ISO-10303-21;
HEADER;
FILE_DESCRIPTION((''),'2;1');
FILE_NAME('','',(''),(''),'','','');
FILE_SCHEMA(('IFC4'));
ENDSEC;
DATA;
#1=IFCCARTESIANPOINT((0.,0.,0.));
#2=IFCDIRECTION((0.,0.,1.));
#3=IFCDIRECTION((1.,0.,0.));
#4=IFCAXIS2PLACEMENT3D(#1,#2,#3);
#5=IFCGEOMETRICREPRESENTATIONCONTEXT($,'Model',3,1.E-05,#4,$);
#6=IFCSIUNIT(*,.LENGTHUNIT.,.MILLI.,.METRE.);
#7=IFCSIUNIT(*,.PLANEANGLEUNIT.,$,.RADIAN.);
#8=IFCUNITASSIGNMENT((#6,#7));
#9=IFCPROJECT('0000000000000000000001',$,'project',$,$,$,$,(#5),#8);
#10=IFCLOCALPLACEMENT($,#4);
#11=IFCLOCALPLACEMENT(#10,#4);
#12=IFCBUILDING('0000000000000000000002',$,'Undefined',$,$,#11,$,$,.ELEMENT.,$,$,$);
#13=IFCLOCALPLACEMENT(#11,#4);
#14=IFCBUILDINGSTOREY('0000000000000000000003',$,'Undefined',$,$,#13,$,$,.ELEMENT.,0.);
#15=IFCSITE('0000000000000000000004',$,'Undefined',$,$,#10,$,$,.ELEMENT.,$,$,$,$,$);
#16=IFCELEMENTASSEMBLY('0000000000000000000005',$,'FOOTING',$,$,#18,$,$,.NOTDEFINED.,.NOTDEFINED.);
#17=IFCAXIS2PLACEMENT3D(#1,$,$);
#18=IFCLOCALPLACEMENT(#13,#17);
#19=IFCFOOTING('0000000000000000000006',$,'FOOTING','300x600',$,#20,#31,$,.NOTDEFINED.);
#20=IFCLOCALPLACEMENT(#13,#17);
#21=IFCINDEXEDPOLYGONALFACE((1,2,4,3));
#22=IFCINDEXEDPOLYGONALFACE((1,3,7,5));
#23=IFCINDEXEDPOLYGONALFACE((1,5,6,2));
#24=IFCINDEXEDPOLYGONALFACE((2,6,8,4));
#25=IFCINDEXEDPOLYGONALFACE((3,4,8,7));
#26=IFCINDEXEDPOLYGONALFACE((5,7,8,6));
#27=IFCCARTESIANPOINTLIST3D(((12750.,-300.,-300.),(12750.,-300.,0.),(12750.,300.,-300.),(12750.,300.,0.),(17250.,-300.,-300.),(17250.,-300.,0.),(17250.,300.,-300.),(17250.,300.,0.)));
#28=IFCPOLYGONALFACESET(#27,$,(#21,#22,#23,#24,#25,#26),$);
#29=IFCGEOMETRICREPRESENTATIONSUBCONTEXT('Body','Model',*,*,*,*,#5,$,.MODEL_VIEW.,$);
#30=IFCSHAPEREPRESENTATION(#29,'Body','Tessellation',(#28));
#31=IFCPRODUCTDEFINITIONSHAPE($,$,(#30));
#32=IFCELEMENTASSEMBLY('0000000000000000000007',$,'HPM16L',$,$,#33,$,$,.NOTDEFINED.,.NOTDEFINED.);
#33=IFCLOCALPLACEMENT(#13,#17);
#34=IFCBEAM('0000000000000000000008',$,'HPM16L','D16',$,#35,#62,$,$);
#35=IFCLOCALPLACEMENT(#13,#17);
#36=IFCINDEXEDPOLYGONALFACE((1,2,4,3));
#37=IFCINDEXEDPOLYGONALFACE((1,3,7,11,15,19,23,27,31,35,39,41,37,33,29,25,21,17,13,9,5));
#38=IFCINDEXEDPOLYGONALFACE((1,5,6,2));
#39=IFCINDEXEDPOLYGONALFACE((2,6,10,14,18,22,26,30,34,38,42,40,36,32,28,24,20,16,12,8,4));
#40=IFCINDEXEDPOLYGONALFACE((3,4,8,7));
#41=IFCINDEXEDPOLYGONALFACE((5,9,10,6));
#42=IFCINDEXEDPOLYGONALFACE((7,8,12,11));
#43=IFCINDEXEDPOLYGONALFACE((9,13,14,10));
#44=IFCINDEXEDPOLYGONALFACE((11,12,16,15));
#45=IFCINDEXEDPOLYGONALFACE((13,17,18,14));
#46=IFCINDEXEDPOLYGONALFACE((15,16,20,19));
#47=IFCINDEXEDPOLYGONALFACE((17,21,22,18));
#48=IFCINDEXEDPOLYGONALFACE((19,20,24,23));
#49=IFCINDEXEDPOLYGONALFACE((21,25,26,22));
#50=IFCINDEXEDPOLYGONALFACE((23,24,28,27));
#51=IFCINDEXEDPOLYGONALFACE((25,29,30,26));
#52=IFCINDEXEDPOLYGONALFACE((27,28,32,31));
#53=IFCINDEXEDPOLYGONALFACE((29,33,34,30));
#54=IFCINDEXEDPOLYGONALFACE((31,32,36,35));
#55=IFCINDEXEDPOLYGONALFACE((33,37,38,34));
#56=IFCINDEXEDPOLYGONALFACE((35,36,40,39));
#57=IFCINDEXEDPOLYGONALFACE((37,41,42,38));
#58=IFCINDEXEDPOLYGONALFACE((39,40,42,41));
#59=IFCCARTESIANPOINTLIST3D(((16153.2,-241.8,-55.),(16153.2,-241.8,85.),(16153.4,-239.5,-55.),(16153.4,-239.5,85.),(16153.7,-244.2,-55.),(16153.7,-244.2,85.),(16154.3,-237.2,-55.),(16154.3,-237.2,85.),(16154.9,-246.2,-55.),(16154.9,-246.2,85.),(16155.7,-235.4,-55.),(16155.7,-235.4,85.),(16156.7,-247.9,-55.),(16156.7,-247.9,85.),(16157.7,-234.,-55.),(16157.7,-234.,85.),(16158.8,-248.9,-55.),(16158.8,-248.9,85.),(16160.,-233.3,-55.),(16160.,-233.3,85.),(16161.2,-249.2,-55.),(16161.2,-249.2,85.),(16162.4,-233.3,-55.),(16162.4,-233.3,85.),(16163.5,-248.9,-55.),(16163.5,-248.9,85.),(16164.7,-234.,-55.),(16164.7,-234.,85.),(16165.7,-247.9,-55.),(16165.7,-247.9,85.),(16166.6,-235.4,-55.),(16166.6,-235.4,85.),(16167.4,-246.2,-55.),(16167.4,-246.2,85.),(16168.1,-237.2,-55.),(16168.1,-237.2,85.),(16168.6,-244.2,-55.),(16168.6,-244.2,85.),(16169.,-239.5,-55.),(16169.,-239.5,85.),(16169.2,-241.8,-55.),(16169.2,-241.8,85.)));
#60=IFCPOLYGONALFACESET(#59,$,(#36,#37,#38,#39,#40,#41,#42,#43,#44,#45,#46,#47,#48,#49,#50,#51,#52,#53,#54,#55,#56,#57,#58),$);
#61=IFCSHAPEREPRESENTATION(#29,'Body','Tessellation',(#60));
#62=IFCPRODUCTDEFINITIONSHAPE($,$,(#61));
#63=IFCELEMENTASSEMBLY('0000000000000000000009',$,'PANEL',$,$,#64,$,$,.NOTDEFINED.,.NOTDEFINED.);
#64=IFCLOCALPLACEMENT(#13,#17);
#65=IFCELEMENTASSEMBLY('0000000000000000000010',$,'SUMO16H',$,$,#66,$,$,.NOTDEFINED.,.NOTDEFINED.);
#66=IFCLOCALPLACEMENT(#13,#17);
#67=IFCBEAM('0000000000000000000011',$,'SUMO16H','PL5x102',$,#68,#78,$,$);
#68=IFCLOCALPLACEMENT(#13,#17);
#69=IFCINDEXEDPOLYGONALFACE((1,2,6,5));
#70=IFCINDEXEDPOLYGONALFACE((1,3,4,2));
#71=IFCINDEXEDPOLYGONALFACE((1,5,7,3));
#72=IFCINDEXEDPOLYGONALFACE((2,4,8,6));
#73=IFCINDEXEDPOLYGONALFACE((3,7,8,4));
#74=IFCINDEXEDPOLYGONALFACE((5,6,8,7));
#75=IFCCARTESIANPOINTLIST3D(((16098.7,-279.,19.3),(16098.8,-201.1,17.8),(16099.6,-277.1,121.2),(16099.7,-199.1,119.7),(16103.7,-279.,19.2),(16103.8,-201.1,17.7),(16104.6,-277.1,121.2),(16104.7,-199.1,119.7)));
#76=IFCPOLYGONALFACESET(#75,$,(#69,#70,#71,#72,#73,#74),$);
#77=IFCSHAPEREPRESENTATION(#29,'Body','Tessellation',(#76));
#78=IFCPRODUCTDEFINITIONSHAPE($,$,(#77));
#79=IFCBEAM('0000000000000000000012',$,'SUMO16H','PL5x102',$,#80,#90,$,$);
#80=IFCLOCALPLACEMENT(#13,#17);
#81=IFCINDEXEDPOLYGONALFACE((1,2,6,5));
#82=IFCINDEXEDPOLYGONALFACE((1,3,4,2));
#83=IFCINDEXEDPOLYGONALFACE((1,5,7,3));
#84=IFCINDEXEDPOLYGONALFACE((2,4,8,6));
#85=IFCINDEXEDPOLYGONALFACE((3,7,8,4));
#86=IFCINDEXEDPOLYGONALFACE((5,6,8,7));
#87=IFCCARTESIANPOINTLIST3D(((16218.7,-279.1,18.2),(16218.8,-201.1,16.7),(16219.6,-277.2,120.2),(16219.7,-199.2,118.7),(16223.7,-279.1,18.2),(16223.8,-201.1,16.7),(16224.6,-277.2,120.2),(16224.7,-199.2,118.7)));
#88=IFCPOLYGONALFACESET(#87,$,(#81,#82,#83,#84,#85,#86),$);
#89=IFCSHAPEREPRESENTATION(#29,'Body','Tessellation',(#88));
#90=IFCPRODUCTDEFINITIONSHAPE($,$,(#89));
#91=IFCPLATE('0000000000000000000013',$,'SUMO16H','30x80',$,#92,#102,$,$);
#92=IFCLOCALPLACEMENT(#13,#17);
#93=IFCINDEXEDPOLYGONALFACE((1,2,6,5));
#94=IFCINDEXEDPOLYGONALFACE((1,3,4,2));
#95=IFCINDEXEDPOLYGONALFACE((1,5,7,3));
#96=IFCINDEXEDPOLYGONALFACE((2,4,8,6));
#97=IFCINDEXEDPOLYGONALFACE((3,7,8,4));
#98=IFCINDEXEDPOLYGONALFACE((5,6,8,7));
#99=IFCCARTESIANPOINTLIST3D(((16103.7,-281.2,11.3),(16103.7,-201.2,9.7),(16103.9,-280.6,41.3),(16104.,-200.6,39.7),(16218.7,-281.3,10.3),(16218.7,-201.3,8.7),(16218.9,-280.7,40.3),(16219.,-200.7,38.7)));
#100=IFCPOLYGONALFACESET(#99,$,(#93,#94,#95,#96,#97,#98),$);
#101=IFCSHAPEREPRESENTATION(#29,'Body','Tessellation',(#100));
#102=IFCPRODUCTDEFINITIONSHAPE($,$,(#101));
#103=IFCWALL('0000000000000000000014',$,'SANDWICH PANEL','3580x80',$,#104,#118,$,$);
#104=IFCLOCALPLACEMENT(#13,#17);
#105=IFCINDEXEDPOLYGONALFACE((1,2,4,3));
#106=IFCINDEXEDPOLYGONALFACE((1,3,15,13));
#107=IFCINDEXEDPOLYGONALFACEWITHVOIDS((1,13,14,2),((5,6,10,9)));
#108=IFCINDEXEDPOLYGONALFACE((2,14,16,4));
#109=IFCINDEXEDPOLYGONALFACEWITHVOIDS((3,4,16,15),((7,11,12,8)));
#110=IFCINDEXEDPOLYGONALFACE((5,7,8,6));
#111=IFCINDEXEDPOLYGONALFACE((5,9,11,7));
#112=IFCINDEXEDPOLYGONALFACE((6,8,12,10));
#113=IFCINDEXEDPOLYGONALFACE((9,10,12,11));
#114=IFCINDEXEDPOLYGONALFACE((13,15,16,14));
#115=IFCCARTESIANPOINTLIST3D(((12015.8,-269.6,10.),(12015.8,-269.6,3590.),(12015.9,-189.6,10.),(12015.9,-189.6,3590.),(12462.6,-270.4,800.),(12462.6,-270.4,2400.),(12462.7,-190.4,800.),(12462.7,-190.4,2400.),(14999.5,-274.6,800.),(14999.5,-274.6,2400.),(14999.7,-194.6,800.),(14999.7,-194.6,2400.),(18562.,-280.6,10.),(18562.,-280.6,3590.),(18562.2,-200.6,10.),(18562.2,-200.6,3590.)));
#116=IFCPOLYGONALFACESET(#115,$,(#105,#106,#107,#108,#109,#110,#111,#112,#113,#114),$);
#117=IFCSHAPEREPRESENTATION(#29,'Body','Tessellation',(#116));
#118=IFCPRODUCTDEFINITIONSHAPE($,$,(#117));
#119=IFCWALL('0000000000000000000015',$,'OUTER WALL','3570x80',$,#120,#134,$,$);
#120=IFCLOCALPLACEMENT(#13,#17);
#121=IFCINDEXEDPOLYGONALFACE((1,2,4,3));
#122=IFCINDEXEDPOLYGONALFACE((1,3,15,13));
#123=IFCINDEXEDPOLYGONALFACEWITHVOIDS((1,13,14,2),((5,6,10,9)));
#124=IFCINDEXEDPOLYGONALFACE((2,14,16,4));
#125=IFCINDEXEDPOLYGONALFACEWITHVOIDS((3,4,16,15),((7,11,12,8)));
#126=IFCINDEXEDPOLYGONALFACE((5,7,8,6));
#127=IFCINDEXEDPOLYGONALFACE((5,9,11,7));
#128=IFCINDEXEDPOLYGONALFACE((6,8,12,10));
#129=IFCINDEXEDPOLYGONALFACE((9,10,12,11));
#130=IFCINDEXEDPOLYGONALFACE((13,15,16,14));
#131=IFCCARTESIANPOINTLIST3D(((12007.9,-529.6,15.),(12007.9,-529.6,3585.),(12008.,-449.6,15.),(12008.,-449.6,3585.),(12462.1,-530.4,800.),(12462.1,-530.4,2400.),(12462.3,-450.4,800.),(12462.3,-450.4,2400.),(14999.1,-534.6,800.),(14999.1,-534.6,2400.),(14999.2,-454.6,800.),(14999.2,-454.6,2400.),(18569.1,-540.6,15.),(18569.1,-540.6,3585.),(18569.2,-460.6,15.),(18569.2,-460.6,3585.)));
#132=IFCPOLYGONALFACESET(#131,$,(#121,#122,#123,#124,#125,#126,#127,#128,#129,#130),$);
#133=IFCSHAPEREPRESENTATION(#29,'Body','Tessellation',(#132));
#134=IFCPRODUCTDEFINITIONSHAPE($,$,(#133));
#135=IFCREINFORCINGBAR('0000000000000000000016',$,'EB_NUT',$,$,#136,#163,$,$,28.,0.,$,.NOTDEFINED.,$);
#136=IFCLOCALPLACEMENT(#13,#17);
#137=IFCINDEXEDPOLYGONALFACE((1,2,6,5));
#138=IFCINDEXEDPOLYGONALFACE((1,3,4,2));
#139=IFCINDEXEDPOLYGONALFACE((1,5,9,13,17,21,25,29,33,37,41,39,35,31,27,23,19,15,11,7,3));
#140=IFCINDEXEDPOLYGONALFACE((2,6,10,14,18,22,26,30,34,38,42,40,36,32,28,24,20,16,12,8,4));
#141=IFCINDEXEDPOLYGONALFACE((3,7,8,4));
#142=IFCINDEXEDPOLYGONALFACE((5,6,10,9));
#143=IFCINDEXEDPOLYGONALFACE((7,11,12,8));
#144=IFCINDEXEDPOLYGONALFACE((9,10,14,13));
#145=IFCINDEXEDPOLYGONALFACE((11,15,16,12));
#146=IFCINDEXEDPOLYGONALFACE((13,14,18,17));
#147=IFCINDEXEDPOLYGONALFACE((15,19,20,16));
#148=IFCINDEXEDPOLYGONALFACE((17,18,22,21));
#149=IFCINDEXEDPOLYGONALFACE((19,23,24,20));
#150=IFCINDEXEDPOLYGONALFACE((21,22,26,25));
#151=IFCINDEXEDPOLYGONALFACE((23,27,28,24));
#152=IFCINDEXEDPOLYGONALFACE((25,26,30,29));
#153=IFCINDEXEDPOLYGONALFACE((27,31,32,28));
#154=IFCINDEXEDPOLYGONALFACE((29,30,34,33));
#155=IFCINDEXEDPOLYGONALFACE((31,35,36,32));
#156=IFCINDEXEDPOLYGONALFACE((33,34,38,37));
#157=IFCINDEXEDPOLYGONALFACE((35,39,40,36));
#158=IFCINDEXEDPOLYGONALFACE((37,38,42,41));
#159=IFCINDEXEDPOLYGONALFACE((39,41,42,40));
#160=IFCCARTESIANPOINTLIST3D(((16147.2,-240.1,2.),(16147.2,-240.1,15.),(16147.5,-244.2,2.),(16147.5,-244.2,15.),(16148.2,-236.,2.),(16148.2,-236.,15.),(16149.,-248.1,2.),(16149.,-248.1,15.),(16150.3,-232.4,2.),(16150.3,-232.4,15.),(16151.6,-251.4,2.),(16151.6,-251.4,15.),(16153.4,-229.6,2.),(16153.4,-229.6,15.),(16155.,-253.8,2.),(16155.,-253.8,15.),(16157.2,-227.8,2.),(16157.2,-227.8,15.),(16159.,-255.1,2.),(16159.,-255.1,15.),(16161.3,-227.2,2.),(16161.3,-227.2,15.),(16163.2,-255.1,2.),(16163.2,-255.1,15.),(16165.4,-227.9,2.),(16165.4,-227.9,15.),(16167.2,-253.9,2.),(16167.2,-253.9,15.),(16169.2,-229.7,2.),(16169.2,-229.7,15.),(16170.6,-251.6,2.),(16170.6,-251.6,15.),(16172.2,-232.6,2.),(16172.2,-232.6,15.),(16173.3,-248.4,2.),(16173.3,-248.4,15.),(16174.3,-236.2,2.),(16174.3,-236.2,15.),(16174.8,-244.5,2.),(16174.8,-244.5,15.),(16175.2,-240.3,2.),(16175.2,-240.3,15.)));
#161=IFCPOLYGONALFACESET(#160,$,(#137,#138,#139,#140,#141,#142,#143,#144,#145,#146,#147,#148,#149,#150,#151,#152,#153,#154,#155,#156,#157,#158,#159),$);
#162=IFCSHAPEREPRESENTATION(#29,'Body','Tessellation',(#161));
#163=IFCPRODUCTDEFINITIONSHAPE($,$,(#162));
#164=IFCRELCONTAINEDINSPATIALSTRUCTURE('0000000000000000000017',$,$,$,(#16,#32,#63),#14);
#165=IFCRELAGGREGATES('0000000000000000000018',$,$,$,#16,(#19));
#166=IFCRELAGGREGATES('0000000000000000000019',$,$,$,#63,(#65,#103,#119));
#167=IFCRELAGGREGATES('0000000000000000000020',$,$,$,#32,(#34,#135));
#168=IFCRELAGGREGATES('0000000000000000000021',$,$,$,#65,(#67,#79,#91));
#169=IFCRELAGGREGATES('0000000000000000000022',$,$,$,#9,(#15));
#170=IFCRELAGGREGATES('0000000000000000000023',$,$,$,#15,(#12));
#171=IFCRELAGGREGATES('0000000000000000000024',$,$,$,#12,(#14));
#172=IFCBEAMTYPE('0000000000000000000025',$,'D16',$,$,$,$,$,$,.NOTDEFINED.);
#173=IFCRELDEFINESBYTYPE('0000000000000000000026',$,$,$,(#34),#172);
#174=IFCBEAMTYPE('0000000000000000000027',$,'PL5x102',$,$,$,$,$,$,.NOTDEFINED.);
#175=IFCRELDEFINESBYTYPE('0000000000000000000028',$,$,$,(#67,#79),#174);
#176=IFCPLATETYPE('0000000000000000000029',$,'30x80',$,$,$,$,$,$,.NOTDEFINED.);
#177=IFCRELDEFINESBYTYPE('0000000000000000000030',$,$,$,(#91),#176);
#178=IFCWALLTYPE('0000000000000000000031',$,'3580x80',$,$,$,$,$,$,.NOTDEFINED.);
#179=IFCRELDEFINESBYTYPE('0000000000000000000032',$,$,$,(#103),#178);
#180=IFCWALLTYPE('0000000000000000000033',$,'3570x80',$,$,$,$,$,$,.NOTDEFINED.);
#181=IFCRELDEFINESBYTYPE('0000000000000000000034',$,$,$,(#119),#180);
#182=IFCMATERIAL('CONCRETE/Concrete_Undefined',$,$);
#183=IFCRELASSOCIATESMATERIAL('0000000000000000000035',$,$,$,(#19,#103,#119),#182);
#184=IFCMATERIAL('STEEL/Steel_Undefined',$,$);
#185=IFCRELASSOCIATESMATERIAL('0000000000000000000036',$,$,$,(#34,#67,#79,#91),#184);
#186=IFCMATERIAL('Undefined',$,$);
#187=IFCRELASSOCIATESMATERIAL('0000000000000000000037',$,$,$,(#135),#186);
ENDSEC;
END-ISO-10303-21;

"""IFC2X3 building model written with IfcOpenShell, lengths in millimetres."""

from ifc_helpers import new_model, entity, si_unit, frame, frame_2d, origin_with_axes, origin_2d_with_axis, place, context, subcontext, project, spatial, polyline, rectangle, circle, outline, extrude, source, transform, mapped, material, type_object, element, aggregate, save


model = new_model("IFC2X3")

# Units and contexts
model_context = context("Model", 3, precision=1e-05, world=origin_with_axes())
body_context = subcontext(model_context, "Body", "Model", "MODEL_VIEW")
ifc_project = project(units=[si_unit("LENGTHUNIT", "METRE", prefix="MILLI"), si_unit("PLANEANGLEUNIT", "RADIAN")], contexts=[model_context])

# Site, building, storey
site_placement = place(None, origin_with_axes())
site = spatial("IfcSite", under=ifc_project, at=site_placement, Name="Undefined", CompositionType="ELEMENT")
building_placement = place(site_placement, origin_with_axes())
building = spatial("IfcBuilding", under=site, at=building_placement, Name="Undefined", CompositionType="ELEMENT")
storey_placement = place(building_placement, origin_with_axes())
storey = spatial("IfcBuildingStorey", under=building, at=storey_placement, Name="Undefined", CompositionType="ELEMENT", Elevation=0.0)

# Element assembly, footing
assembly_1_placement = place(storey_placement, origin_with_axes())
assembly_1 = element("IfcElementAssembly", 1, at=assembly_1_placement, inside=storey, Name="FOOTING", AssemblyPlace="NOTDEFINED", PredefinedType="NOTDEFINED")
ifc_material_1 = material(Name="CONCRETE/Concrete_Undefined")
footing_placement = place(assembly_1_placement, frame((12750.0, 0.0, -150.0), z_axis=(0.0, 0.0, 1.0), x_axis=(1.0, 0.0, 0.0)))
footing = element("IfcFooting", 2, at=footing_placement, material=ifc_material_1, Name="FOOTING", Description="300x600", PredefinedType="NOTDEFINED", context=body_context, shape_type="SweptSolid", body=[
    extrude(rectangle(XDim=600.0, YDim=300.0, at=origin_2d_with_axis()), frame((4500.0, 0.0, 0.0), z_axis=(-1.0, 0.0, 0.0), x_axis=(0.0, -1.0, 0.0)), (0.0, 0.0, 1.0), 4500.0),
])
aggregate(assembly_1, [footing])

# Element assembly, beam
assembly_2_placement = place(storey_placement, origin_with_axes())
assembly_2 = element("IfcElementAssembly", 3, at=assembly_2_placement, inside=storey, Name="HPM16L", AssemblyPlace="NOTDEFINED", PredefinedType="NOTDEFINED")
ifc_material_2 = material(Name="STEEL/Steel_Undefined")
beam_type_1 = type_object("IfcBeamType", Name="D16", PredefinedType="NOTDEFINED")
beam_1_placement = place(assembly_2_placement, frame((16161.2, -241.2, 85.0), z_axis=(1.0, 0.0, 0.0), x_axis=(0.0, 0.0, -1.0)))
beam_1 = element("IfcBeam", 4, at=beam_1_placement, type_object=beam_type_1, material=ifc_material_2, Name="HPM16L", Description="D16", context=body_context, shape_type="SweptSolid", body=[
    extrude(circle(Radius=8.0, at=origin_2d_with_axis()), frame((140.0, 0.0, 0.0), z_axis=(-1.0, 0.0, 0.0), x_axis=(0.0, -1.0, 0.0)), (0.0, 0.0, 1.0), 140.0),
])

# Element assemblies, beams, plate, walls, openings
assembly_3_placement = place(storey_placement, origin_with_axes())
assembly_3 = element("IfcElementAssembly", 5, at=assembly_3_placement, inside=storey, Name="PANEL", AssemblyPlace="NOTDEFINED", PredefinedType="NOTDEFINED")
assembly_4_placement = place(assembly_3_placement, origin_with_axes())
assembly_4 = element("IfcElementAssembly", 6, at=assembly_4_placement, Name="SUMO16H", AssemblyPlace="NOTDEFINED", PredefinedType="NOTDEFINED")
beam_type_2 = type_object("IfcBeamType", Name="PL5x102", PredefinedType="NOTDEFINED")
beam_2_placement = place(assembly_4_placement, frame((16101.7, -200.1, 68.7), z_axis=(0.008618, 0.019092, 0.999781), x_axis=(-0.000494, -0.999818, 0.019097)))
beam_2 = element("IfcBeam", 7, at=beam_2_placement, type_object=beam_type_2, material=ifc_material_2, Name="SUMO16H", Description="PL5x102", context=body_context, shape_type="SweptSolid", body=[
    extrude(rectangle(XDim=5.0, YDim=102.0, at=origin_2d_with_axis()), frame((78.0, 0.0, 0.0), z_axis=(-1.0, 0.0, 0.0), x_axis=(0.0, -1.0, 0.0)), (0.0, 0.0, 1.0), 78.0),
])
beam_3_placement = place(assembly_4_placement, frame((16221.7, -200.2, 67.7), z_axis=(0.008618, 0.019092, 0.999781), x_axis=(-0.000494, -0.999818, 0.019097)))
beam_3 = element("IfcBeam", 8, at=beam_3_placement, type_object=beam_type_2, material=ifc_material_2, Name="SUMO16H", Description="PL5x102", context=body_context, shape_type="SweptSolid", body=[
    extrude(rectangle(XDim=5.0, YDim=102.0, at=origin_2d_with_axis()), frame((78.0, 0.0, 0.0), z_axis=(-1.0, 0.0, 0.0), x_axis=(0.0, -1.0, 0.0)), (0.0, 0.0, 1.0), 78.0),
])
plate_type = type_object("IfcPlateType", Name="30x80", PredefinedType="NOTDEFINED")
plate_placement = place(assembly_4_placement, frame((16218.8, -201.0, 23.7), z_axis=(0.008618, 0.019092, 0.999781), x_axis=(-0.999963, 0.000658, 0.008607)))
plate = element("IfcPlate", 9, at=plate_placement, type_object=plate_type, material=ifc_material_2, Name="SUMO16H", Description="30x80", context=body_context, shape_type="SweptSolid", body=[
    extrude(outline(polyline([(0.0, 0.0), (115.0, 0.0), (115.0, 80.0), (0.0, 80.0), (0.0, 0.0)])), frame((0.0, 0.0, -15.0), z_axis=(0.0, 0.0, 1.0), x_axis=(1.0, 0.0, 0.0)), (0.0, 0.0, 1.0), 30.0),
])
wall_type_1 = type_object("IfcWallType", Name="3580x80", PredefinedType="NOTDEFINED")
wall_1_placement = place(assembly_3_placement, frame((12015.9, -229.6, 10.0), z_axis=(0.0, 0.0, 1.0), x_axis=(0.999999, -0.001684, 0.0)))
wall_1 = element("IfcWall", 10, at=wall_1_placement, type_object=wall_type_1, material=ifc_material_1, Name="SANDWICH PANEL", Description="3580x80", context=body_context, shape_type="SweptSolid", body=[
    extrude(rectangle(XDim=6546.2, YDim=80.0, at=frame_2d((0.0, 3273.1), x_axis=(0.0, -1.0))), frame((0.0, 0.0, 0.0), z_axis=(0.0, 0.0, 1.0), x_axis=(0.0, -1.0, 0.0)), (0.0, 0.0, 1.0), 3580.0),
])
opening_1_placement = place(assembly_3_placement, frame((12015.9, -229.6, 10.0), z_axis=(0.0, 0.0, 1.0), x_axis=(0.999999, -0.001684, 0.0)))
element("IfcOpeningElement", 11, at=opening_1_placement, cuts=wall_1, ObjectType="Recess", context=body_context, shape_type="SweptSolid", body=[
    extrude(outline(polyline([(0.0, 0.0), (2537.0, 0.0), (2537.0, 1600.0), (0.0, 1600.0), (0.0, 0.0)])), frame((446.8, 90.0, 790.0), z_axis=(0.0, -1.0, 0.0), x_axis=(1.0, 0.0, 0.0)), (0.0, 0.0, 1.0), 180.0),
])
wall_type_2 = type_object("IfcWallType", Name="3570x80", PredefinedType="NOTDEFINED")
wall_2_placement = place(assembly_3_placement, frame((12007.9, -489.6, 15.0), z_axis=(0.0, 0.0, 1.0), x_axis=(0.999999, -0.001684, 0.0)))
wall_2 = element("IfcWall", 12, at=wall_2_placement, type_object=wall_type_2, material=ifc_material_1, Name="OUTER WALL", Description="3570x80", context=body_context, shape_type="SweptSolid", body=[
    extrude(rectangle(XDim=6561.2, YDim=80.0, at=frame_2d((0.0, 3280.6), x_axis=(0.0, -1.0))), frame((0.0, 0.0, 0.0), z_axis=(0.0, 0.0, 1.0), x_axis=(0.0, -1.0, 0.0)), (0.0, 0.0, 1.0), 3570.0),
])
opening_2_placement = place(assembly_3_placement, frame((12007.9, -489.6, 15.0), z_axis=(0.0, 0.0, 1.0), x_axis=(0.999999, -0.001684, 0.0)))
element("IfcOpeningElement", 13, at=opening_2_placement, cuts=wall_2, ObjectType="Recess", context=body_context, shape_type="SweptSolid", body=[
    extrude(outline(polyline([(0.0, 0.0), (2537.0, 0.0), (2537.0, 1600.0), (0.0, 1600.0), (0.0, 0.0)])), frame((454.3, 90.0, 785.0), z_axis=(0.0, -1.0, 0.0), x_axis=(1.0, 0.0, 0.0)), (0.0, 0.0, 1.0), 180.0),
])
aggregate(assembly_3, [assembly_4, wall_1, wall_2])

# Reinforcing bar
ifc_material_3 = material(Name="Undefined")
shared_shape_1 = source(origin_with_axes(), body_context, "Body", "AdvancedSweptSolid", [
    entity("IfcSweptDiskSolid", entity("IfcTrimmedCurve", entity("IfcLine", entity("IfcCartesianPoint", [0.0, 0.0, 0.0]), entity("IfcVector", entity("IfcDirection", [1.0, 0.0, 0.0]), 1.0)), [entity("IfcParameterValue", 0.0)], [entity("IfcParameterValue", 13.0)], True, "PARAMETER"), 14.0, None, 0.0, 13.0),
])
reinforcing_bar_1_placement = place(assembly_2_placement, frame((16161.2, -241.2, 15.0), z_axis=(0.008664, 0.999962, 0.0), x_axis=(0.0, 0.0, -1.0)))
reinforcing_bar_1 = element("IfcReinforcingBar", 14, at=reinforcing_bar_1_placement, material=ifc_material_3, Name="EB_NUT", BarRole="NOTDEFINED", CrossSectionArea=0.0, NominalDiameter=28.0, context=body_context, shape_type="MappedRepresentation", body=[
    mapped(shared_shape_1, transform((0.0, 0.0, 0.0))),
])
aggregate(assembly_2, [beam_1, reinforcing_bar_1])

aggregate(assembly_4, [beam_2, beam_3, plate])

save(model, "model.ifc")
